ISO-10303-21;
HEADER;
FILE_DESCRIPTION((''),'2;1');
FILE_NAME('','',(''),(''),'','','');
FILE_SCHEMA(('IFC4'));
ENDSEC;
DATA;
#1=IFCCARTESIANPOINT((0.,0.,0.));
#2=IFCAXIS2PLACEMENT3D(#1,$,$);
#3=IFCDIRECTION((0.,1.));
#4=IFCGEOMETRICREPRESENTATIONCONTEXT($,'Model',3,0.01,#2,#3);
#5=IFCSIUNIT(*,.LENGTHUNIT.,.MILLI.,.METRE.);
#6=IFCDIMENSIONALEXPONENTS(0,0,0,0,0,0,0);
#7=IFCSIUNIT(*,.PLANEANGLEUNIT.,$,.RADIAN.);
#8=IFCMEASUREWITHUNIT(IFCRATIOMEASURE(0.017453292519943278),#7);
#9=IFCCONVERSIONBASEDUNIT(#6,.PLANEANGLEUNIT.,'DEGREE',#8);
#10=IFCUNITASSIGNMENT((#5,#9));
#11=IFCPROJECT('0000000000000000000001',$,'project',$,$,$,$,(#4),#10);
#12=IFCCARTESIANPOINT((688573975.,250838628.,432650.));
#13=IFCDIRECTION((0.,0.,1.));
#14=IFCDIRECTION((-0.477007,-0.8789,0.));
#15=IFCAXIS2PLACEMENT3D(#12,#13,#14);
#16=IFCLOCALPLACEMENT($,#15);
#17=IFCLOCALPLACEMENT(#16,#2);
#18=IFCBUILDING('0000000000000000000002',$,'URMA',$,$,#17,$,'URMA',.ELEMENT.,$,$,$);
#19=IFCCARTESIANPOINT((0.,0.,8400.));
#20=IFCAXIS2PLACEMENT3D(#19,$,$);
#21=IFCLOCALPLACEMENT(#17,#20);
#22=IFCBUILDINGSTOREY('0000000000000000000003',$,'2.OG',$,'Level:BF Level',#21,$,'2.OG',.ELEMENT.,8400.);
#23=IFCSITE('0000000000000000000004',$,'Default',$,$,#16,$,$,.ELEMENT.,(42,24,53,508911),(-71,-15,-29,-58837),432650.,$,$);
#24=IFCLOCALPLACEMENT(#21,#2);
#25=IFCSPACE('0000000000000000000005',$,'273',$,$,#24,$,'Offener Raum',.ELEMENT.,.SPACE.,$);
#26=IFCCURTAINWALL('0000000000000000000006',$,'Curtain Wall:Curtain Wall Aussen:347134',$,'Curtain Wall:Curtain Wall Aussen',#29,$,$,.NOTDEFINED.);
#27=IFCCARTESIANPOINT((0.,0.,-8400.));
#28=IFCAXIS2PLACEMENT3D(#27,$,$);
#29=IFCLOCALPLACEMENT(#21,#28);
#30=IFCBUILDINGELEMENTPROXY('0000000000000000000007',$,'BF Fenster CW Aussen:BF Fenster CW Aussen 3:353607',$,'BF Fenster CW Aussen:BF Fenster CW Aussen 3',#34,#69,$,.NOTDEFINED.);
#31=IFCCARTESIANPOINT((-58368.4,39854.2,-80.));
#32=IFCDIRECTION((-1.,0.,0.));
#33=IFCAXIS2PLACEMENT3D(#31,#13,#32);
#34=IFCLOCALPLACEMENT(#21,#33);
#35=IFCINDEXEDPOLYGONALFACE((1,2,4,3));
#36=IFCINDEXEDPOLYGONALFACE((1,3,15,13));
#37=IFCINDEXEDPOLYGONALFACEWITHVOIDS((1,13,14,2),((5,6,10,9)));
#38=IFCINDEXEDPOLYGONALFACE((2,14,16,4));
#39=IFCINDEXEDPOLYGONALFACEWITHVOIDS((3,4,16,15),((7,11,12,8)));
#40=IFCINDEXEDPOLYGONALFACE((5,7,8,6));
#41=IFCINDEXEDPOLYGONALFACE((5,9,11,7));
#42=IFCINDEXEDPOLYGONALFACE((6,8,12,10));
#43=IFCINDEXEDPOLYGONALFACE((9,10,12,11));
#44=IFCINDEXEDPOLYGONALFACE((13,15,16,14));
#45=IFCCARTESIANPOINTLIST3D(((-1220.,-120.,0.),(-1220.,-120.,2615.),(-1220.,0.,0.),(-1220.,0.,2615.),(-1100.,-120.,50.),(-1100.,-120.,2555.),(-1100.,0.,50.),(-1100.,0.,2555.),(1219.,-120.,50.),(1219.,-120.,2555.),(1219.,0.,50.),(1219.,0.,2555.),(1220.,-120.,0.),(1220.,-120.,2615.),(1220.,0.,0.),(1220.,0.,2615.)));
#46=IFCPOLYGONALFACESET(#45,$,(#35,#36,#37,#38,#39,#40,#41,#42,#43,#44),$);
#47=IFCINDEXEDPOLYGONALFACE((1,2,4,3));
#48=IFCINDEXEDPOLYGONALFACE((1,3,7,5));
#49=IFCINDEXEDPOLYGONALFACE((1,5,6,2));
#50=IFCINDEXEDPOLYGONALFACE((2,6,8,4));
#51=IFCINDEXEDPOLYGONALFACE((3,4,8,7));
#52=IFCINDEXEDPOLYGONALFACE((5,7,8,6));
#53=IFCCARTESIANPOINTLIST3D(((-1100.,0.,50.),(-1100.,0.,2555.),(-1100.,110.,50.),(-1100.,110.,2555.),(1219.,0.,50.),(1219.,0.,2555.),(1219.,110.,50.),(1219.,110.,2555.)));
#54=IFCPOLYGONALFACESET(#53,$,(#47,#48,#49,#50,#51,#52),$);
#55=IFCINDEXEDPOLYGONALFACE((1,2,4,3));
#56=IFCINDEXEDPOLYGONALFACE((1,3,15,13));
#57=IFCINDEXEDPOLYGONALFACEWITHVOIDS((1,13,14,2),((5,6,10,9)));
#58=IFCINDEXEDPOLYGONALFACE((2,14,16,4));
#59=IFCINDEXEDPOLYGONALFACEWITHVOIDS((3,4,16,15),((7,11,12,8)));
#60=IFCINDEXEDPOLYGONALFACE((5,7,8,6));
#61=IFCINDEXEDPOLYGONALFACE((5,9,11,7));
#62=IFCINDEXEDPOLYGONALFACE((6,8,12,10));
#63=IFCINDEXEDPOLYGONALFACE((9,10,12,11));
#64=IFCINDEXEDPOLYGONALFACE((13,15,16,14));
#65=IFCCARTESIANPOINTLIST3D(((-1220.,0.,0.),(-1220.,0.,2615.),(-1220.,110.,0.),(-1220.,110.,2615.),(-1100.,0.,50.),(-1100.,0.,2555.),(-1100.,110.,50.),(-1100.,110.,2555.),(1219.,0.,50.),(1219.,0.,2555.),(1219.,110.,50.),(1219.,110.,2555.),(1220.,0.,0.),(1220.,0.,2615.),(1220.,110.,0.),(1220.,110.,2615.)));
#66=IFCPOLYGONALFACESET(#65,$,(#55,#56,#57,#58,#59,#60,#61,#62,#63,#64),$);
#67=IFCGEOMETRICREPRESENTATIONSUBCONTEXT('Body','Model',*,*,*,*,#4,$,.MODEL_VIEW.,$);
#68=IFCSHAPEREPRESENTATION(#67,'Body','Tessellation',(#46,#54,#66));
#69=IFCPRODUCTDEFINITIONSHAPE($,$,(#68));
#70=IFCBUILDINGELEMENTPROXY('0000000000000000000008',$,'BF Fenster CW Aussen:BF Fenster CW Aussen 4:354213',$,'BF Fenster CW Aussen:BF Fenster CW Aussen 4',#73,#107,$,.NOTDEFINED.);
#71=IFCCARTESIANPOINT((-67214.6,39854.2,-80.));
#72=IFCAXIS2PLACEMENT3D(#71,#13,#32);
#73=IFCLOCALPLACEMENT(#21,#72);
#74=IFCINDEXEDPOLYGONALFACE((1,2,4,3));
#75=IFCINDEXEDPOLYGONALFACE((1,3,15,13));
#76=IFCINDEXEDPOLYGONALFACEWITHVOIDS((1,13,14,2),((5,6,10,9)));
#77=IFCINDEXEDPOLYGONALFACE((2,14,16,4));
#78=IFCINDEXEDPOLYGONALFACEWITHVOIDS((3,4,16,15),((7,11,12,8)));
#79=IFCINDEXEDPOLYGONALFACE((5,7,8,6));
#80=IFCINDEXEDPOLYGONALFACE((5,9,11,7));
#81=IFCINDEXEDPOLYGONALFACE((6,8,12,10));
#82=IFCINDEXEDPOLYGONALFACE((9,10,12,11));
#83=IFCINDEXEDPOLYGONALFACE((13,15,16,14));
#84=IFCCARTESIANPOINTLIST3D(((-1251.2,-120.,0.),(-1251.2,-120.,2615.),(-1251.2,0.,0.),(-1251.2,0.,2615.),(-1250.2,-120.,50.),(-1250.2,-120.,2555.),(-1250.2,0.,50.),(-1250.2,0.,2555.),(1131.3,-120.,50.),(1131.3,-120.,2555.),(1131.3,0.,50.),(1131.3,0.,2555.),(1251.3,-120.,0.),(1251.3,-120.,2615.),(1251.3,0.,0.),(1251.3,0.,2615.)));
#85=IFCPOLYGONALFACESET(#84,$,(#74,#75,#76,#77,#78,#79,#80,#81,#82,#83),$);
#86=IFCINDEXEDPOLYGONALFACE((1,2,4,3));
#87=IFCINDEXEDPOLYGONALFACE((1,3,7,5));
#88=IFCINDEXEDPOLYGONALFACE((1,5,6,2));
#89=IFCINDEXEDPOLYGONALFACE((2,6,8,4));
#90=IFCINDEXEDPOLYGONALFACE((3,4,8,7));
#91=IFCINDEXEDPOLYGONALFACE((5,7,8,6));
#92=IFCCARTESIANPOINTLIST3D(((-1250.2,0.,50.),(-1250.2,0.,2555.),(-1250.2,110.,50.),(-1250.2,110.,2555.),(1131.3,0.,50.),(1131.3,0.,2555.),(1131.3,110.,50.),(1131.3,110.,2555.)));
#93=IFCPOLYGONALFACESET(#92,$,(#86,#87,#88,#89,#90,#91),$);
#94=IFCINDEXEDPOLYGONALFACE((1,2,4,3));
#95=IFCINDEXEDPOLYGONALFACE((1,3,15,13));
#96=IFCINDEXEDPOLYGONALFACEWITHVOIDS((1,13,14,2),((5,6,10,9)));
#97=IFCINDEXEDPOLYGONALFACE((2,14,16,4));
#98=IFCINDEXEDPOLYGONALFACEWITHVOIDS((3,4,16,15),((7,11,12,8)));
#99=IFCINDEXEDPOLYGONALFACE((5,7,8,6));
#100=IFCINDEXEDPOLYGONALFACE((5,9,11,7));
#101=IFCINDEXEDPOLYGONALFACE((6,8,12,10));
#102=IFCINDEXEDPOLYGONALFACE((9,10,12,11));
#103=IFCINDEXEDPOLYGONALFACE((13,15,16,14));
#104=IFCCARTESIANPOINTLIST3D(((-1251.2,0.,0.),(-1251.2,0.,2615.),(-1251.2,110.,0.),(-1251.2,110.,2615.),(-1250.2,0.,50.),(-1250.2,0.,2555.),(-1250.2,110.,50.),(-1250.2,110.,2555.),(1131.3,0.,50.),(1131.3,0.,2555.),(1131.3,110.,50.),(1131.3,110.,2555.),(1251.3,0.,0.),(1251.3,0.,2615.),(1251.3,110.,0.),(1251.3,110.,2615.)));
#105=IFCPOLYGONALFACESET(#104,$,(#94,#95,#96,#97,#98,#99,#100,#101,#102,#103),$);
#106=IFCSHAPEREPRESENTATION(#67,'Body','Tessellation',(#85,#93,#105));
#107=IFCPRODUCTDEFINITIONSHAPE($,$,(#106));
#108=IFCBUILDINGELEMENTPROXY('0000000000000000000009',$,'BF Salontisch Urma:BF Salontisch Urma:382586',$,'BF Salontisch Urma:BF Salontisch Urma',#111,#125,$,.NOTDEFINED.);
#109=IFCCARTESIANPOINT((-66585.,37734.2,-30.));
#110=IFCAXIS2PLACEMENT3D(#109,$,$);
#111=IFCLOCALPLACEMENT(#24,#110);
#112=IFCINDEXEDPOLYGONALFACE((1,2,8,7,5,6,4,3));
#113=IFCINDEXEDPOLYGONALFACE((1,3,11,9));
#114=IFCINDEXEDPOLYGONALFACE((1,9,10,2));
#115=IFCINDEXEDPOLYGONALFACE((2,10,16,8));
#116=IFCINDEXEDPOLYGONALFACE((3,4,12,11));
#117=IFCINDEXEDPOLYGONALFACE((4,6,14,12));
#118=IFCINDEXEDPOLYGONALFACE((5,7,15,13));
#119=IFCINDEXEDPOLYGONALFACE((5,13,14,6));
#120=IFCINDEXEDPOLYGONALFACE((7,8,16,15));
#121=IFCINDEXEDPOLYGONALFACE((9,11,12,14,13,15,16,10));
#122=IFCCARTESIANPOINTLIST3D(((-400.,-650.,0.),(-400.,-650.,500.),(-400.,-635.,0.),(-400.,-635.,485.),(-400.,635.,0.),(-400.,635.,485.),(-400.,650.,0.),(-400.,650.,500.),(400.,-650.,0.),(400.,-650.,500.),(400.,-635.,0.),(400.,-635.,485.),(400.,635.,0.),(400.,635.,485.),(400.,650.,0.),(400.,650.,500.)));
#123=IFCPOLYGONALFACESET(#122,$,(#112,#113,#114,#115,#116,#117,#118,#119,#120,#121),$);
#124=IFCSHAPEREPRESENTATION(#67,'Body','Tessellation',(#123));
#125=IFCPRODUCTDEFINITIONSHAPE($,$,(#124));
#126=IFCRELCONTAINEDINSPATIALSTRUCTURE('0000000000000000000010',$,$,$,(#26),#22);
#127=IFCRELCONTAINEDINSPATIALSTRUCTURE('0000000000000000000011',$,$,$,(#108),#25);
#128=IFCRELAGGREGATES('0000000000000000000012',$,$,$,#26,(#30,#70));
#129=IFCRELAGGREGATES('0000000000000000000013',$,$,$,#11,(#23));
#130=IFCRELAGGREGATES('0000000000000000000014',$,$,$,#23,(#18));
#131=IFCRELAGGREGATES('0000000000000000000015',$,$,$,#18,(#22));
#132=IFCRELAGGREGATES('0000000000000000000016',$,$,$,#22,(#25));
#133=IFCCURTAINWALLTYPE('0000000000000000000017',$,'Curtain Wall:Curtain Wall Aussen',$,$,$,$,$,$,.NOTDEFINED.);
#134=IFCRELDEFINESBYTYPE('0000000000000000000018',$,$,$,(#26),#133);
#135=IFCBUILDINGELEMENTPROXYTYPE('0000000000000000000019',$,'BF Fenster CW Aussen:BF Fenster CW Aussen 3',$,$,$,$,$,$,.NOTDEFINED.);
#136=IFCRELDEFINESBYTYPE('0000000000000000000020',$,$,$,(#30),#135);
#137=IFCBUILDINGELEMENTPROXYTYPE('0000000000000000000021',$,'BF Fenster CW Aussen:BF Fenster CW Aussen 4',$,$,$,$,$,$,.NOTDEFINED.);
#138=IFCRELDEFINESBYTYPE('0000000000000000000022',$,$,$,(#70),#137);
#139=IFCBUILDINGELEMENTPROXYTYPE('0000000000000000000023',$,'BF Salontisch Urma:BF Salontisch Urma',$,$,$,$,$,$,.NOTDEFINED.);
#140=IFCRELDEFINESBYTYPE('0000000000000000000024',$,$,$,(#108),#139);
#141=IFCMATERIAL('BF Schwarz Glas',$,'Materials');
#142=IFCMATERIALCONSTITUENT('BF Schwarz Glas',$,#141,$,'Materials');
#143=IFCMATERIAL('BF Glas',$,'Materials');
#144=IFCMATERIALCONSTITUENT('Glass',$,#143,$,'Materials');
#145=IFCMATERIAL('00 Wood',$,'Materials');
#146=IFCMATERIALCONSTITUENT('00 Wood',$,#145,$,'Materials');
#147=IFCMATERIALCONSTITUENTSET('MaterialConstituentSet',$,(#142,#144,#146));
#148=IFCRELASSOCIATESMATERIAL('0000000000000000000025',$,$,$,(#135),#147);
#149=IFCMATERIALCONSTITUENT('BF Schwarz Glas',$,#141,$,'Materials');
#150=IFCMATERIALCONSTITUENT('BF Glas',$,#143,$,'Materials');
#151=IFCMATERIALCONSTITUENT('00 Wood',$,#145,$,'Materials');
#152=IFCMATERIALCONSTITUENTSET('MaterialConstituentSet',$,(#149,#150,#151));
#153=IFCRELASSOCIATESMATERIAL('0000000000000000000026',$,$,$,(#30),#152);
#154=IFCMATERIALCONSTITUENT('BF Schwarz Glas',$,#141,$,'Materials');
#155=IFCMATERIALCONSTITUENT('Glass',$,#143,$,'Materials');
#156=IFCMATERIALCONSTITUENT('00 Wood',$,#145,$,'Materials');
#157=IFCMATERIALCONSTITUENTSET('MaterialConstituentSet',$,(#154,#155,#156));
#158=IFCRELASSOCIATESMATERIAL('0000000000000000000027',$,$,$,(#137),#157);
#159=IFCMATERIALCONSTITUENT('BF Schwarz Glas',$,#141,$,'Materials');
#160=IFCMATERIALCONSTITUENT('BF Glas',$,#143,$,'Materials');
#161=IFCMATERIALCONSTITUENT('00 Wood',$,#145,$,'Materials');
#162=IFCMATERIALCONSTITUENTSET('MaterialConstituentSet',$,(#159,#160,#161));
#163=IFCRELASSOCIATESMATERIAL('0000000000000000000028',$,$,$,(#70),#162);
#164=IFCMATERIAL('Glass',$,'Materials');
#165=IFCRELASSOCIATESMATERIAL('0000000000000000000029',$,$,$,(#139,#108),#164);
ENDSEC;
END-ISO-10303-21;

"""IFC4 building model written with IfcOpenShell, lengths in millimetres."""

from ifc_helpers import new_model, entity, si_unit, converted_unit, direction, frame, origin, place, context, subcontext, project, spatial, indexed_curve, outline, extrude, source, transform, mapped, material, constituent, constituent_set, type_object, type_shapes, element, aggregate, save


model = new_model("IFC4")

# Units and contexts
model_context = context("Model", 3, precision=0.01, world=origin(), true_north=direction((0.0, 1.0)))
body_context = subcontext(model_context, "Body", "Model", "MODEL_VIEW")
ifc_project = project(units=[si_unit("LENGTHUNIT", "METRE", prefix="MILLI"), converted_unit("PLANEANGLEUNIT", "DEGREE", entity("IfcRatioMeasure", 0.017453292519943278), si_unit("PLANEANGLEUNIT", "RADIAN"), dimensions=[0, 0, 0, 0, 0, 0, 0])], contexts=[model_context])

# Site, building, storey
site_placement = place(None, frame((688573975.0, 250838628.0, 432650.0), z_axis=(0.0, 0.0, 1.0), x_axis=(-0.477007, -0.8789, 0.0)))
site = spatial("IfcSite", under=ifc_project, at=site_placement, Name="Default", CompositionType="ELEMENT", RefLatitude=(42, 24, 53, 508911), RefLongitude=(-71, -15, -29, -58837), RefElevation=432650.0)
building_placement = place(site_placement, origin())
building = spatial("IfcBuilding", under=site, at=building_placement, Name="URMA", LongName="URMA", CompositionType="ELEMENT")
storey_placement = place(building_placement, frame((0.0, 0.0, 8400.0)))
storey = spatial("IfcBuildingStorey", under=building, at=storey_placement, Name="2.OG", ObjectType="Level:BF Level", LongName="2.OG", CompositionType="ELEMENT", Elevation=8400.0)

# Shared definitions
curtain_wall_type = type_object("IfcCurtainWallType", Name="Curtain Wall:Curtain Wall Aussen", PredefinedType="NOTDEFINED")

# Curtain wall, building element proxies
curtain_wall_1_placement = place(storey_placement, frame((0.0, 0.0, -8400.0)))
curtain_wall_1 = element("IfcCurtainWall", 1, at=curtain_wall_1_placement, inside=storey, type_object=curtain_wall_type, Name="Curtain Wall:Curtain Wall Aussen:347134", ObjectType="Curtain Wall:Curtain Wall Aussen", PredefinedType="NOTDEFINED")
ifc_material_1 = material(Name="BF Schwarz Glas", Category="Materials")
ifc_material_2 = material(Name="BF Glas", Category="Materials")
ifc_material_3 = material(Name="00 Wood", Category="Materials")
ifc_constituent_1 = constituent(ifc_material_1, Name="BF Schwarz Glas", Category="Materials")
ifc_constituent_2 = constituent(ifc_material_2, Name="BF Glas", Category="Materials")
ifc_constituent_3 = constituent(ifc_material_3, Name="00 Wood", Category="Materials")
ifc_constituent_set_1 = constituent_set(constituents=[ifc_constituent_1, ifc_constituent_2, ifc_constituent_3], Name="MaterialConstituentSet")
ifc_constituent_4 = constituent(ifc_material_1, Name="BF Schwarz Glas", Category="Materials")
ifc_constituent_5 = constituent(ifc_material_2, Name="Glass", Category="Materials")
ifc_constituent_6 = constituent(ifc_material_3, Name="00 Wood", Category="Materials")
ifc_constituent_set_2 = constituent_set(constituents=[ifc_constituent_4, ifc_constituent_5, ifc_constituent_6], Name="MaterialConstituentSet")
building_element_proxy_type_1 = type_object("IfcBuildingElementProxyType", Name="BF Fenster CW Aussen:BF Fenster CW Aussen 3", PredefinedType="NOTDEFINED", material=ifc_constituent_set_2)
shared_shape_1 = source(origin(), body_context, "Body", "SweptSolid", [
    extrude(outline(indexed_curve([(-1220.0, -1307.5), (1220.0, -1307.5), (1220.0, 1307.5), (-1220.0, 1307.5), (-1220.0, -1307.5)], self_intersect=False), holes=[indexed_curve([(-1100.0, -1247.5), (-1100.0, 1257.5), (1219.0, 1257.5), (1219.0, -1247.5), (-1100.0, -1247.5)], self_intersect=False)]), frame((0.0, -120.0, 1307.5), z_axis=(0.0, 1.0, 0.0), x_axis=(1.0, 0.0, 0.0)), (0.0, 0.0, 1.0), 120.0),
    extrude(outline(indexed_curve([(-55.0, -1159.5), (55.0, -1159.5), (55.0, 1159.5), (-55.0, 1159.5), (-55.0, -1159.5)], self_intersect=False)), frame((59.5, 55.0, 50.0), z_axis=(0.0, 0.0, 1.0), x_axis=(0.0, 1.0, 0.0)), (0.0, 0.0, 1.0), 2505.0),
    extrude(outline(indexed_curve([(-1220.0, -1307.5), (1220.0, -1307.5), (1220.0, 1307.5), (-1220.0, 1307.5), (-1220.0, -1307.5)], self_intersect=False), holes=[indexed_curve([(-1100.0, -1247.5), (-1100.0, 1257.5), (1219.0, 1257.5), (1219.0, -1247.5), (-1100.0, -1247.5)], self_intersect=False)]), frame((0.0, 0.0, 1307.5), z_axis=(0.0, 1.0, 0.0), x_axis=(1.0, 0.0, 0.0)), (0.0, 0.0, 1.0), 110.0),
])
type_shapes(building_element_proxy_type_1, [shared_shape_1])
proxy_1_placement = place(storey_placement, frame((-58368.4, 39854.2, -80.0), z_axis=(0.0, 0.0, 1.0), x_axis=(-1.0, 0.0, 0.0)))
proxy_1 = element("IfcBuildingElementProxy", 2, at=proxy_1_placement, type_object=building_element_proxy_type_1, material=ifc_constituent_set_1, Name="BF Fenster CW Aussen:BF Fenster CW Aussen 3:353607", ObjectType="BF Fenster CW Aussen:BF Fenster CW Aussen 3", PredefinedType="NOTDEFINED", context=body_context, shape_type="MappedRepresentation", body=[
    mapped(shared_shape_1, transform((0.0, 0.0, 0.0), scale=1.0)),
])
ifc_constituent_7 = constituent(ifc_material_1, Name="BF Schwarz Glas", Category="Materials")
ifc_constituent_8 = constituent(ifc_material_2, Name="BF Glas", Category="Materials")
ifc_constituent_9 = constituent(ifc_material_3, Name="00 Wood", Category="Materials")
ifc_constituent_set_3 = constituent_set(constituents=[ifc_constituent_7, ifc_constituent_8, ifc_constituent_9], Name="MaterialConstituentSet")
ifc_constituent_10 = constituent(ifc_material_1, Name="BF Schwarz Glas", Category="Materials")
ifc_constituent_11 = constituent(ifc_material_2, Name="Glass", Category="Materials")
ifc_constituent_12 = constituent(ifc_material_3, Name="00 Wood", Category="Materials")
ifc_constituent_set_4 = constituent_set(constituents=[ifc_constituent_10, ifc_constituent_11, ifc_constituent_12], Name="MaterialConstituentSet")
building_element_proxy_type_2 = type_object("IfcBuildingElementProxyType", Name="BF Fenster CW Aussen:BF Fenster CW Aussen 4", PredefinedType="NOTDEFINED", material=ifc_constituent_set_4)
shared_shape_2 = source(origin(), body_context, "Body", "SweptSolid", [
    extrude(outline(indexed_curve([(-1251.3, -1307.5), (1251.3, -1307.5), (1251.3, 1307.5), (-1251.3, 1307.5), (-1251.3, -1307.5)], self_intersect=False), holes=[indexed_curve([(-1250.3, -1247.5), (-1250.3, 1257.5), (1131.2, 1257.5), (1131.2, -1247.5), (-1250.3, -1247.5)], self_intersect=False)]), frame((0.0, -120.0, 1307.5), z_axis=(0.0, 1.0, 0.0), x_axis=(1.0, 0.0, 0.0)), (0.0, 0.0, 1.0), 120.0),
    extrude(outline(indexed_curve([(-55.0, -1190.8), (55.0, -1190.8), (55.0, 1190.8), (-55.0, 1190.8), (-55.0, -1190.8)], self_intersect=False)), frame((-59.5, 55.0, 50.0), z_axis=(0.0, 0.0, 1.0), x_axis=(0.0, 1.0, 0.0)), (0.0, 0.0, 1.0), 2505.0),
    extrude(outline(indexed_curve([(-1251.3, -1307.5), (1251.3, -1307.5), (1251.3, 1307.5), (-1251.3, 1307.5), (-1251.3, -1307.5)], self_intersect=False), holes=[indexed_curve([(-1250.3, -1247.5), (-1250.3, 1257.5), (1131.2, 1257.5), (1131.2, -1247.5), (-1250.3, -1247.5)], self_intersect=False)]), frame((0.0, 0.0, 1307.5), z_axis=(0.0, 1.0, 0.0), x_axis=(1.0, 0.0, 0.0)), (0.0, 0.0, 1.0), 110.0),
])
type_shapes(building_element_proxy_type_2, [shared_shape_2])
proxy_2_placement = place(storey_placement, frame((-67214.6, 39854.2, -80.0), z_axis=(0.0, 0.0, 1.0), x_axis=(-1.0, 0.0, 0.0)))
proxy_2 = element("IfcBuildingElementProxy", 3, at=proxy_2_placement, type_object=building_element_proxy_type_2, material=ifc_constituent_set_3, Name="BF Fenster CW Aussen:BF Fenster CW Aussen 4:354213", ObjectType="BF Fenster CW Aussen:BF Fenster CW Aussen 4", PredefinedType="NOTDEFINED", context=body_context, shape_type="MappedRepresentation", body=[
    mapped(shared_shape_2, transform((0.0, 0.0, 0.0), scale=1.0)),
])
aggregate(curtain_wall_1, [proxy_1, proxy_2])

# Shared definitions
space_1_placement = place(storey_placement, origin())
space_1 = spatial("IfcSpace", under=storey, at=space_1_placement, Name="273", LongName="Offener Raum", CompositionType="ELEMENT", PredefinedType="SPACE")

# Building element proxy
ifc_material_4 = material(Name="Glass", Category="Materials")
building_element_proxy_type_3 = type_object("IfcBuildingElementProxyType", Name="BF Salontisch Urma:BF Salontisch Urma", PredefinedType="NOTDEFINED", material=ifc_material_4)
shared_shape_3 = source(origin(), body_context, "Body", "SweptSolid", [
    extrude(outline(indexed_curve([(-650.0, -253.7), (650.0, -253.7), (650.0, 246.3), (635.0, 246.3), (635.0, -238.7), (-635.0, -238.7), (-635.0, 246.2), (-650.0, 246.2), (-650.0, -253.7)], self_intersect=False)), frame((-400.0, 0.0, 246.2), z_axis=(1.0, 0.0, 0.0), x_axis=(0.0, -1.0, 0.0)), (0.0, 0.0, 1.0), 800.0),
])
type_shapes(building_element_proxy_type_3, [shared_shape_3])
proxy_3_placement = place(space_1_placement, frame((-66585.0, 37734.2, -30.0)))
element("IfcBuildingElementProxy", 4, at=proxy_3_placement, inside=space_1, type_object=building_element_proxy_type_3, material=ifc_material_4, Name="BF Salontisch Urma:BF Salontisch Urma:382586", ObjectType="BF Salontisch Urma:BF Salontisch Urma", PredefinedType="NOTDEFINED", context=body_context, shape_type="MappedRepresentation", body=[
    mapped(shared_shape_3, transform((0.0, 0.0, 0.0), scale=1.0)),
])

save(model, "model.ifc")
